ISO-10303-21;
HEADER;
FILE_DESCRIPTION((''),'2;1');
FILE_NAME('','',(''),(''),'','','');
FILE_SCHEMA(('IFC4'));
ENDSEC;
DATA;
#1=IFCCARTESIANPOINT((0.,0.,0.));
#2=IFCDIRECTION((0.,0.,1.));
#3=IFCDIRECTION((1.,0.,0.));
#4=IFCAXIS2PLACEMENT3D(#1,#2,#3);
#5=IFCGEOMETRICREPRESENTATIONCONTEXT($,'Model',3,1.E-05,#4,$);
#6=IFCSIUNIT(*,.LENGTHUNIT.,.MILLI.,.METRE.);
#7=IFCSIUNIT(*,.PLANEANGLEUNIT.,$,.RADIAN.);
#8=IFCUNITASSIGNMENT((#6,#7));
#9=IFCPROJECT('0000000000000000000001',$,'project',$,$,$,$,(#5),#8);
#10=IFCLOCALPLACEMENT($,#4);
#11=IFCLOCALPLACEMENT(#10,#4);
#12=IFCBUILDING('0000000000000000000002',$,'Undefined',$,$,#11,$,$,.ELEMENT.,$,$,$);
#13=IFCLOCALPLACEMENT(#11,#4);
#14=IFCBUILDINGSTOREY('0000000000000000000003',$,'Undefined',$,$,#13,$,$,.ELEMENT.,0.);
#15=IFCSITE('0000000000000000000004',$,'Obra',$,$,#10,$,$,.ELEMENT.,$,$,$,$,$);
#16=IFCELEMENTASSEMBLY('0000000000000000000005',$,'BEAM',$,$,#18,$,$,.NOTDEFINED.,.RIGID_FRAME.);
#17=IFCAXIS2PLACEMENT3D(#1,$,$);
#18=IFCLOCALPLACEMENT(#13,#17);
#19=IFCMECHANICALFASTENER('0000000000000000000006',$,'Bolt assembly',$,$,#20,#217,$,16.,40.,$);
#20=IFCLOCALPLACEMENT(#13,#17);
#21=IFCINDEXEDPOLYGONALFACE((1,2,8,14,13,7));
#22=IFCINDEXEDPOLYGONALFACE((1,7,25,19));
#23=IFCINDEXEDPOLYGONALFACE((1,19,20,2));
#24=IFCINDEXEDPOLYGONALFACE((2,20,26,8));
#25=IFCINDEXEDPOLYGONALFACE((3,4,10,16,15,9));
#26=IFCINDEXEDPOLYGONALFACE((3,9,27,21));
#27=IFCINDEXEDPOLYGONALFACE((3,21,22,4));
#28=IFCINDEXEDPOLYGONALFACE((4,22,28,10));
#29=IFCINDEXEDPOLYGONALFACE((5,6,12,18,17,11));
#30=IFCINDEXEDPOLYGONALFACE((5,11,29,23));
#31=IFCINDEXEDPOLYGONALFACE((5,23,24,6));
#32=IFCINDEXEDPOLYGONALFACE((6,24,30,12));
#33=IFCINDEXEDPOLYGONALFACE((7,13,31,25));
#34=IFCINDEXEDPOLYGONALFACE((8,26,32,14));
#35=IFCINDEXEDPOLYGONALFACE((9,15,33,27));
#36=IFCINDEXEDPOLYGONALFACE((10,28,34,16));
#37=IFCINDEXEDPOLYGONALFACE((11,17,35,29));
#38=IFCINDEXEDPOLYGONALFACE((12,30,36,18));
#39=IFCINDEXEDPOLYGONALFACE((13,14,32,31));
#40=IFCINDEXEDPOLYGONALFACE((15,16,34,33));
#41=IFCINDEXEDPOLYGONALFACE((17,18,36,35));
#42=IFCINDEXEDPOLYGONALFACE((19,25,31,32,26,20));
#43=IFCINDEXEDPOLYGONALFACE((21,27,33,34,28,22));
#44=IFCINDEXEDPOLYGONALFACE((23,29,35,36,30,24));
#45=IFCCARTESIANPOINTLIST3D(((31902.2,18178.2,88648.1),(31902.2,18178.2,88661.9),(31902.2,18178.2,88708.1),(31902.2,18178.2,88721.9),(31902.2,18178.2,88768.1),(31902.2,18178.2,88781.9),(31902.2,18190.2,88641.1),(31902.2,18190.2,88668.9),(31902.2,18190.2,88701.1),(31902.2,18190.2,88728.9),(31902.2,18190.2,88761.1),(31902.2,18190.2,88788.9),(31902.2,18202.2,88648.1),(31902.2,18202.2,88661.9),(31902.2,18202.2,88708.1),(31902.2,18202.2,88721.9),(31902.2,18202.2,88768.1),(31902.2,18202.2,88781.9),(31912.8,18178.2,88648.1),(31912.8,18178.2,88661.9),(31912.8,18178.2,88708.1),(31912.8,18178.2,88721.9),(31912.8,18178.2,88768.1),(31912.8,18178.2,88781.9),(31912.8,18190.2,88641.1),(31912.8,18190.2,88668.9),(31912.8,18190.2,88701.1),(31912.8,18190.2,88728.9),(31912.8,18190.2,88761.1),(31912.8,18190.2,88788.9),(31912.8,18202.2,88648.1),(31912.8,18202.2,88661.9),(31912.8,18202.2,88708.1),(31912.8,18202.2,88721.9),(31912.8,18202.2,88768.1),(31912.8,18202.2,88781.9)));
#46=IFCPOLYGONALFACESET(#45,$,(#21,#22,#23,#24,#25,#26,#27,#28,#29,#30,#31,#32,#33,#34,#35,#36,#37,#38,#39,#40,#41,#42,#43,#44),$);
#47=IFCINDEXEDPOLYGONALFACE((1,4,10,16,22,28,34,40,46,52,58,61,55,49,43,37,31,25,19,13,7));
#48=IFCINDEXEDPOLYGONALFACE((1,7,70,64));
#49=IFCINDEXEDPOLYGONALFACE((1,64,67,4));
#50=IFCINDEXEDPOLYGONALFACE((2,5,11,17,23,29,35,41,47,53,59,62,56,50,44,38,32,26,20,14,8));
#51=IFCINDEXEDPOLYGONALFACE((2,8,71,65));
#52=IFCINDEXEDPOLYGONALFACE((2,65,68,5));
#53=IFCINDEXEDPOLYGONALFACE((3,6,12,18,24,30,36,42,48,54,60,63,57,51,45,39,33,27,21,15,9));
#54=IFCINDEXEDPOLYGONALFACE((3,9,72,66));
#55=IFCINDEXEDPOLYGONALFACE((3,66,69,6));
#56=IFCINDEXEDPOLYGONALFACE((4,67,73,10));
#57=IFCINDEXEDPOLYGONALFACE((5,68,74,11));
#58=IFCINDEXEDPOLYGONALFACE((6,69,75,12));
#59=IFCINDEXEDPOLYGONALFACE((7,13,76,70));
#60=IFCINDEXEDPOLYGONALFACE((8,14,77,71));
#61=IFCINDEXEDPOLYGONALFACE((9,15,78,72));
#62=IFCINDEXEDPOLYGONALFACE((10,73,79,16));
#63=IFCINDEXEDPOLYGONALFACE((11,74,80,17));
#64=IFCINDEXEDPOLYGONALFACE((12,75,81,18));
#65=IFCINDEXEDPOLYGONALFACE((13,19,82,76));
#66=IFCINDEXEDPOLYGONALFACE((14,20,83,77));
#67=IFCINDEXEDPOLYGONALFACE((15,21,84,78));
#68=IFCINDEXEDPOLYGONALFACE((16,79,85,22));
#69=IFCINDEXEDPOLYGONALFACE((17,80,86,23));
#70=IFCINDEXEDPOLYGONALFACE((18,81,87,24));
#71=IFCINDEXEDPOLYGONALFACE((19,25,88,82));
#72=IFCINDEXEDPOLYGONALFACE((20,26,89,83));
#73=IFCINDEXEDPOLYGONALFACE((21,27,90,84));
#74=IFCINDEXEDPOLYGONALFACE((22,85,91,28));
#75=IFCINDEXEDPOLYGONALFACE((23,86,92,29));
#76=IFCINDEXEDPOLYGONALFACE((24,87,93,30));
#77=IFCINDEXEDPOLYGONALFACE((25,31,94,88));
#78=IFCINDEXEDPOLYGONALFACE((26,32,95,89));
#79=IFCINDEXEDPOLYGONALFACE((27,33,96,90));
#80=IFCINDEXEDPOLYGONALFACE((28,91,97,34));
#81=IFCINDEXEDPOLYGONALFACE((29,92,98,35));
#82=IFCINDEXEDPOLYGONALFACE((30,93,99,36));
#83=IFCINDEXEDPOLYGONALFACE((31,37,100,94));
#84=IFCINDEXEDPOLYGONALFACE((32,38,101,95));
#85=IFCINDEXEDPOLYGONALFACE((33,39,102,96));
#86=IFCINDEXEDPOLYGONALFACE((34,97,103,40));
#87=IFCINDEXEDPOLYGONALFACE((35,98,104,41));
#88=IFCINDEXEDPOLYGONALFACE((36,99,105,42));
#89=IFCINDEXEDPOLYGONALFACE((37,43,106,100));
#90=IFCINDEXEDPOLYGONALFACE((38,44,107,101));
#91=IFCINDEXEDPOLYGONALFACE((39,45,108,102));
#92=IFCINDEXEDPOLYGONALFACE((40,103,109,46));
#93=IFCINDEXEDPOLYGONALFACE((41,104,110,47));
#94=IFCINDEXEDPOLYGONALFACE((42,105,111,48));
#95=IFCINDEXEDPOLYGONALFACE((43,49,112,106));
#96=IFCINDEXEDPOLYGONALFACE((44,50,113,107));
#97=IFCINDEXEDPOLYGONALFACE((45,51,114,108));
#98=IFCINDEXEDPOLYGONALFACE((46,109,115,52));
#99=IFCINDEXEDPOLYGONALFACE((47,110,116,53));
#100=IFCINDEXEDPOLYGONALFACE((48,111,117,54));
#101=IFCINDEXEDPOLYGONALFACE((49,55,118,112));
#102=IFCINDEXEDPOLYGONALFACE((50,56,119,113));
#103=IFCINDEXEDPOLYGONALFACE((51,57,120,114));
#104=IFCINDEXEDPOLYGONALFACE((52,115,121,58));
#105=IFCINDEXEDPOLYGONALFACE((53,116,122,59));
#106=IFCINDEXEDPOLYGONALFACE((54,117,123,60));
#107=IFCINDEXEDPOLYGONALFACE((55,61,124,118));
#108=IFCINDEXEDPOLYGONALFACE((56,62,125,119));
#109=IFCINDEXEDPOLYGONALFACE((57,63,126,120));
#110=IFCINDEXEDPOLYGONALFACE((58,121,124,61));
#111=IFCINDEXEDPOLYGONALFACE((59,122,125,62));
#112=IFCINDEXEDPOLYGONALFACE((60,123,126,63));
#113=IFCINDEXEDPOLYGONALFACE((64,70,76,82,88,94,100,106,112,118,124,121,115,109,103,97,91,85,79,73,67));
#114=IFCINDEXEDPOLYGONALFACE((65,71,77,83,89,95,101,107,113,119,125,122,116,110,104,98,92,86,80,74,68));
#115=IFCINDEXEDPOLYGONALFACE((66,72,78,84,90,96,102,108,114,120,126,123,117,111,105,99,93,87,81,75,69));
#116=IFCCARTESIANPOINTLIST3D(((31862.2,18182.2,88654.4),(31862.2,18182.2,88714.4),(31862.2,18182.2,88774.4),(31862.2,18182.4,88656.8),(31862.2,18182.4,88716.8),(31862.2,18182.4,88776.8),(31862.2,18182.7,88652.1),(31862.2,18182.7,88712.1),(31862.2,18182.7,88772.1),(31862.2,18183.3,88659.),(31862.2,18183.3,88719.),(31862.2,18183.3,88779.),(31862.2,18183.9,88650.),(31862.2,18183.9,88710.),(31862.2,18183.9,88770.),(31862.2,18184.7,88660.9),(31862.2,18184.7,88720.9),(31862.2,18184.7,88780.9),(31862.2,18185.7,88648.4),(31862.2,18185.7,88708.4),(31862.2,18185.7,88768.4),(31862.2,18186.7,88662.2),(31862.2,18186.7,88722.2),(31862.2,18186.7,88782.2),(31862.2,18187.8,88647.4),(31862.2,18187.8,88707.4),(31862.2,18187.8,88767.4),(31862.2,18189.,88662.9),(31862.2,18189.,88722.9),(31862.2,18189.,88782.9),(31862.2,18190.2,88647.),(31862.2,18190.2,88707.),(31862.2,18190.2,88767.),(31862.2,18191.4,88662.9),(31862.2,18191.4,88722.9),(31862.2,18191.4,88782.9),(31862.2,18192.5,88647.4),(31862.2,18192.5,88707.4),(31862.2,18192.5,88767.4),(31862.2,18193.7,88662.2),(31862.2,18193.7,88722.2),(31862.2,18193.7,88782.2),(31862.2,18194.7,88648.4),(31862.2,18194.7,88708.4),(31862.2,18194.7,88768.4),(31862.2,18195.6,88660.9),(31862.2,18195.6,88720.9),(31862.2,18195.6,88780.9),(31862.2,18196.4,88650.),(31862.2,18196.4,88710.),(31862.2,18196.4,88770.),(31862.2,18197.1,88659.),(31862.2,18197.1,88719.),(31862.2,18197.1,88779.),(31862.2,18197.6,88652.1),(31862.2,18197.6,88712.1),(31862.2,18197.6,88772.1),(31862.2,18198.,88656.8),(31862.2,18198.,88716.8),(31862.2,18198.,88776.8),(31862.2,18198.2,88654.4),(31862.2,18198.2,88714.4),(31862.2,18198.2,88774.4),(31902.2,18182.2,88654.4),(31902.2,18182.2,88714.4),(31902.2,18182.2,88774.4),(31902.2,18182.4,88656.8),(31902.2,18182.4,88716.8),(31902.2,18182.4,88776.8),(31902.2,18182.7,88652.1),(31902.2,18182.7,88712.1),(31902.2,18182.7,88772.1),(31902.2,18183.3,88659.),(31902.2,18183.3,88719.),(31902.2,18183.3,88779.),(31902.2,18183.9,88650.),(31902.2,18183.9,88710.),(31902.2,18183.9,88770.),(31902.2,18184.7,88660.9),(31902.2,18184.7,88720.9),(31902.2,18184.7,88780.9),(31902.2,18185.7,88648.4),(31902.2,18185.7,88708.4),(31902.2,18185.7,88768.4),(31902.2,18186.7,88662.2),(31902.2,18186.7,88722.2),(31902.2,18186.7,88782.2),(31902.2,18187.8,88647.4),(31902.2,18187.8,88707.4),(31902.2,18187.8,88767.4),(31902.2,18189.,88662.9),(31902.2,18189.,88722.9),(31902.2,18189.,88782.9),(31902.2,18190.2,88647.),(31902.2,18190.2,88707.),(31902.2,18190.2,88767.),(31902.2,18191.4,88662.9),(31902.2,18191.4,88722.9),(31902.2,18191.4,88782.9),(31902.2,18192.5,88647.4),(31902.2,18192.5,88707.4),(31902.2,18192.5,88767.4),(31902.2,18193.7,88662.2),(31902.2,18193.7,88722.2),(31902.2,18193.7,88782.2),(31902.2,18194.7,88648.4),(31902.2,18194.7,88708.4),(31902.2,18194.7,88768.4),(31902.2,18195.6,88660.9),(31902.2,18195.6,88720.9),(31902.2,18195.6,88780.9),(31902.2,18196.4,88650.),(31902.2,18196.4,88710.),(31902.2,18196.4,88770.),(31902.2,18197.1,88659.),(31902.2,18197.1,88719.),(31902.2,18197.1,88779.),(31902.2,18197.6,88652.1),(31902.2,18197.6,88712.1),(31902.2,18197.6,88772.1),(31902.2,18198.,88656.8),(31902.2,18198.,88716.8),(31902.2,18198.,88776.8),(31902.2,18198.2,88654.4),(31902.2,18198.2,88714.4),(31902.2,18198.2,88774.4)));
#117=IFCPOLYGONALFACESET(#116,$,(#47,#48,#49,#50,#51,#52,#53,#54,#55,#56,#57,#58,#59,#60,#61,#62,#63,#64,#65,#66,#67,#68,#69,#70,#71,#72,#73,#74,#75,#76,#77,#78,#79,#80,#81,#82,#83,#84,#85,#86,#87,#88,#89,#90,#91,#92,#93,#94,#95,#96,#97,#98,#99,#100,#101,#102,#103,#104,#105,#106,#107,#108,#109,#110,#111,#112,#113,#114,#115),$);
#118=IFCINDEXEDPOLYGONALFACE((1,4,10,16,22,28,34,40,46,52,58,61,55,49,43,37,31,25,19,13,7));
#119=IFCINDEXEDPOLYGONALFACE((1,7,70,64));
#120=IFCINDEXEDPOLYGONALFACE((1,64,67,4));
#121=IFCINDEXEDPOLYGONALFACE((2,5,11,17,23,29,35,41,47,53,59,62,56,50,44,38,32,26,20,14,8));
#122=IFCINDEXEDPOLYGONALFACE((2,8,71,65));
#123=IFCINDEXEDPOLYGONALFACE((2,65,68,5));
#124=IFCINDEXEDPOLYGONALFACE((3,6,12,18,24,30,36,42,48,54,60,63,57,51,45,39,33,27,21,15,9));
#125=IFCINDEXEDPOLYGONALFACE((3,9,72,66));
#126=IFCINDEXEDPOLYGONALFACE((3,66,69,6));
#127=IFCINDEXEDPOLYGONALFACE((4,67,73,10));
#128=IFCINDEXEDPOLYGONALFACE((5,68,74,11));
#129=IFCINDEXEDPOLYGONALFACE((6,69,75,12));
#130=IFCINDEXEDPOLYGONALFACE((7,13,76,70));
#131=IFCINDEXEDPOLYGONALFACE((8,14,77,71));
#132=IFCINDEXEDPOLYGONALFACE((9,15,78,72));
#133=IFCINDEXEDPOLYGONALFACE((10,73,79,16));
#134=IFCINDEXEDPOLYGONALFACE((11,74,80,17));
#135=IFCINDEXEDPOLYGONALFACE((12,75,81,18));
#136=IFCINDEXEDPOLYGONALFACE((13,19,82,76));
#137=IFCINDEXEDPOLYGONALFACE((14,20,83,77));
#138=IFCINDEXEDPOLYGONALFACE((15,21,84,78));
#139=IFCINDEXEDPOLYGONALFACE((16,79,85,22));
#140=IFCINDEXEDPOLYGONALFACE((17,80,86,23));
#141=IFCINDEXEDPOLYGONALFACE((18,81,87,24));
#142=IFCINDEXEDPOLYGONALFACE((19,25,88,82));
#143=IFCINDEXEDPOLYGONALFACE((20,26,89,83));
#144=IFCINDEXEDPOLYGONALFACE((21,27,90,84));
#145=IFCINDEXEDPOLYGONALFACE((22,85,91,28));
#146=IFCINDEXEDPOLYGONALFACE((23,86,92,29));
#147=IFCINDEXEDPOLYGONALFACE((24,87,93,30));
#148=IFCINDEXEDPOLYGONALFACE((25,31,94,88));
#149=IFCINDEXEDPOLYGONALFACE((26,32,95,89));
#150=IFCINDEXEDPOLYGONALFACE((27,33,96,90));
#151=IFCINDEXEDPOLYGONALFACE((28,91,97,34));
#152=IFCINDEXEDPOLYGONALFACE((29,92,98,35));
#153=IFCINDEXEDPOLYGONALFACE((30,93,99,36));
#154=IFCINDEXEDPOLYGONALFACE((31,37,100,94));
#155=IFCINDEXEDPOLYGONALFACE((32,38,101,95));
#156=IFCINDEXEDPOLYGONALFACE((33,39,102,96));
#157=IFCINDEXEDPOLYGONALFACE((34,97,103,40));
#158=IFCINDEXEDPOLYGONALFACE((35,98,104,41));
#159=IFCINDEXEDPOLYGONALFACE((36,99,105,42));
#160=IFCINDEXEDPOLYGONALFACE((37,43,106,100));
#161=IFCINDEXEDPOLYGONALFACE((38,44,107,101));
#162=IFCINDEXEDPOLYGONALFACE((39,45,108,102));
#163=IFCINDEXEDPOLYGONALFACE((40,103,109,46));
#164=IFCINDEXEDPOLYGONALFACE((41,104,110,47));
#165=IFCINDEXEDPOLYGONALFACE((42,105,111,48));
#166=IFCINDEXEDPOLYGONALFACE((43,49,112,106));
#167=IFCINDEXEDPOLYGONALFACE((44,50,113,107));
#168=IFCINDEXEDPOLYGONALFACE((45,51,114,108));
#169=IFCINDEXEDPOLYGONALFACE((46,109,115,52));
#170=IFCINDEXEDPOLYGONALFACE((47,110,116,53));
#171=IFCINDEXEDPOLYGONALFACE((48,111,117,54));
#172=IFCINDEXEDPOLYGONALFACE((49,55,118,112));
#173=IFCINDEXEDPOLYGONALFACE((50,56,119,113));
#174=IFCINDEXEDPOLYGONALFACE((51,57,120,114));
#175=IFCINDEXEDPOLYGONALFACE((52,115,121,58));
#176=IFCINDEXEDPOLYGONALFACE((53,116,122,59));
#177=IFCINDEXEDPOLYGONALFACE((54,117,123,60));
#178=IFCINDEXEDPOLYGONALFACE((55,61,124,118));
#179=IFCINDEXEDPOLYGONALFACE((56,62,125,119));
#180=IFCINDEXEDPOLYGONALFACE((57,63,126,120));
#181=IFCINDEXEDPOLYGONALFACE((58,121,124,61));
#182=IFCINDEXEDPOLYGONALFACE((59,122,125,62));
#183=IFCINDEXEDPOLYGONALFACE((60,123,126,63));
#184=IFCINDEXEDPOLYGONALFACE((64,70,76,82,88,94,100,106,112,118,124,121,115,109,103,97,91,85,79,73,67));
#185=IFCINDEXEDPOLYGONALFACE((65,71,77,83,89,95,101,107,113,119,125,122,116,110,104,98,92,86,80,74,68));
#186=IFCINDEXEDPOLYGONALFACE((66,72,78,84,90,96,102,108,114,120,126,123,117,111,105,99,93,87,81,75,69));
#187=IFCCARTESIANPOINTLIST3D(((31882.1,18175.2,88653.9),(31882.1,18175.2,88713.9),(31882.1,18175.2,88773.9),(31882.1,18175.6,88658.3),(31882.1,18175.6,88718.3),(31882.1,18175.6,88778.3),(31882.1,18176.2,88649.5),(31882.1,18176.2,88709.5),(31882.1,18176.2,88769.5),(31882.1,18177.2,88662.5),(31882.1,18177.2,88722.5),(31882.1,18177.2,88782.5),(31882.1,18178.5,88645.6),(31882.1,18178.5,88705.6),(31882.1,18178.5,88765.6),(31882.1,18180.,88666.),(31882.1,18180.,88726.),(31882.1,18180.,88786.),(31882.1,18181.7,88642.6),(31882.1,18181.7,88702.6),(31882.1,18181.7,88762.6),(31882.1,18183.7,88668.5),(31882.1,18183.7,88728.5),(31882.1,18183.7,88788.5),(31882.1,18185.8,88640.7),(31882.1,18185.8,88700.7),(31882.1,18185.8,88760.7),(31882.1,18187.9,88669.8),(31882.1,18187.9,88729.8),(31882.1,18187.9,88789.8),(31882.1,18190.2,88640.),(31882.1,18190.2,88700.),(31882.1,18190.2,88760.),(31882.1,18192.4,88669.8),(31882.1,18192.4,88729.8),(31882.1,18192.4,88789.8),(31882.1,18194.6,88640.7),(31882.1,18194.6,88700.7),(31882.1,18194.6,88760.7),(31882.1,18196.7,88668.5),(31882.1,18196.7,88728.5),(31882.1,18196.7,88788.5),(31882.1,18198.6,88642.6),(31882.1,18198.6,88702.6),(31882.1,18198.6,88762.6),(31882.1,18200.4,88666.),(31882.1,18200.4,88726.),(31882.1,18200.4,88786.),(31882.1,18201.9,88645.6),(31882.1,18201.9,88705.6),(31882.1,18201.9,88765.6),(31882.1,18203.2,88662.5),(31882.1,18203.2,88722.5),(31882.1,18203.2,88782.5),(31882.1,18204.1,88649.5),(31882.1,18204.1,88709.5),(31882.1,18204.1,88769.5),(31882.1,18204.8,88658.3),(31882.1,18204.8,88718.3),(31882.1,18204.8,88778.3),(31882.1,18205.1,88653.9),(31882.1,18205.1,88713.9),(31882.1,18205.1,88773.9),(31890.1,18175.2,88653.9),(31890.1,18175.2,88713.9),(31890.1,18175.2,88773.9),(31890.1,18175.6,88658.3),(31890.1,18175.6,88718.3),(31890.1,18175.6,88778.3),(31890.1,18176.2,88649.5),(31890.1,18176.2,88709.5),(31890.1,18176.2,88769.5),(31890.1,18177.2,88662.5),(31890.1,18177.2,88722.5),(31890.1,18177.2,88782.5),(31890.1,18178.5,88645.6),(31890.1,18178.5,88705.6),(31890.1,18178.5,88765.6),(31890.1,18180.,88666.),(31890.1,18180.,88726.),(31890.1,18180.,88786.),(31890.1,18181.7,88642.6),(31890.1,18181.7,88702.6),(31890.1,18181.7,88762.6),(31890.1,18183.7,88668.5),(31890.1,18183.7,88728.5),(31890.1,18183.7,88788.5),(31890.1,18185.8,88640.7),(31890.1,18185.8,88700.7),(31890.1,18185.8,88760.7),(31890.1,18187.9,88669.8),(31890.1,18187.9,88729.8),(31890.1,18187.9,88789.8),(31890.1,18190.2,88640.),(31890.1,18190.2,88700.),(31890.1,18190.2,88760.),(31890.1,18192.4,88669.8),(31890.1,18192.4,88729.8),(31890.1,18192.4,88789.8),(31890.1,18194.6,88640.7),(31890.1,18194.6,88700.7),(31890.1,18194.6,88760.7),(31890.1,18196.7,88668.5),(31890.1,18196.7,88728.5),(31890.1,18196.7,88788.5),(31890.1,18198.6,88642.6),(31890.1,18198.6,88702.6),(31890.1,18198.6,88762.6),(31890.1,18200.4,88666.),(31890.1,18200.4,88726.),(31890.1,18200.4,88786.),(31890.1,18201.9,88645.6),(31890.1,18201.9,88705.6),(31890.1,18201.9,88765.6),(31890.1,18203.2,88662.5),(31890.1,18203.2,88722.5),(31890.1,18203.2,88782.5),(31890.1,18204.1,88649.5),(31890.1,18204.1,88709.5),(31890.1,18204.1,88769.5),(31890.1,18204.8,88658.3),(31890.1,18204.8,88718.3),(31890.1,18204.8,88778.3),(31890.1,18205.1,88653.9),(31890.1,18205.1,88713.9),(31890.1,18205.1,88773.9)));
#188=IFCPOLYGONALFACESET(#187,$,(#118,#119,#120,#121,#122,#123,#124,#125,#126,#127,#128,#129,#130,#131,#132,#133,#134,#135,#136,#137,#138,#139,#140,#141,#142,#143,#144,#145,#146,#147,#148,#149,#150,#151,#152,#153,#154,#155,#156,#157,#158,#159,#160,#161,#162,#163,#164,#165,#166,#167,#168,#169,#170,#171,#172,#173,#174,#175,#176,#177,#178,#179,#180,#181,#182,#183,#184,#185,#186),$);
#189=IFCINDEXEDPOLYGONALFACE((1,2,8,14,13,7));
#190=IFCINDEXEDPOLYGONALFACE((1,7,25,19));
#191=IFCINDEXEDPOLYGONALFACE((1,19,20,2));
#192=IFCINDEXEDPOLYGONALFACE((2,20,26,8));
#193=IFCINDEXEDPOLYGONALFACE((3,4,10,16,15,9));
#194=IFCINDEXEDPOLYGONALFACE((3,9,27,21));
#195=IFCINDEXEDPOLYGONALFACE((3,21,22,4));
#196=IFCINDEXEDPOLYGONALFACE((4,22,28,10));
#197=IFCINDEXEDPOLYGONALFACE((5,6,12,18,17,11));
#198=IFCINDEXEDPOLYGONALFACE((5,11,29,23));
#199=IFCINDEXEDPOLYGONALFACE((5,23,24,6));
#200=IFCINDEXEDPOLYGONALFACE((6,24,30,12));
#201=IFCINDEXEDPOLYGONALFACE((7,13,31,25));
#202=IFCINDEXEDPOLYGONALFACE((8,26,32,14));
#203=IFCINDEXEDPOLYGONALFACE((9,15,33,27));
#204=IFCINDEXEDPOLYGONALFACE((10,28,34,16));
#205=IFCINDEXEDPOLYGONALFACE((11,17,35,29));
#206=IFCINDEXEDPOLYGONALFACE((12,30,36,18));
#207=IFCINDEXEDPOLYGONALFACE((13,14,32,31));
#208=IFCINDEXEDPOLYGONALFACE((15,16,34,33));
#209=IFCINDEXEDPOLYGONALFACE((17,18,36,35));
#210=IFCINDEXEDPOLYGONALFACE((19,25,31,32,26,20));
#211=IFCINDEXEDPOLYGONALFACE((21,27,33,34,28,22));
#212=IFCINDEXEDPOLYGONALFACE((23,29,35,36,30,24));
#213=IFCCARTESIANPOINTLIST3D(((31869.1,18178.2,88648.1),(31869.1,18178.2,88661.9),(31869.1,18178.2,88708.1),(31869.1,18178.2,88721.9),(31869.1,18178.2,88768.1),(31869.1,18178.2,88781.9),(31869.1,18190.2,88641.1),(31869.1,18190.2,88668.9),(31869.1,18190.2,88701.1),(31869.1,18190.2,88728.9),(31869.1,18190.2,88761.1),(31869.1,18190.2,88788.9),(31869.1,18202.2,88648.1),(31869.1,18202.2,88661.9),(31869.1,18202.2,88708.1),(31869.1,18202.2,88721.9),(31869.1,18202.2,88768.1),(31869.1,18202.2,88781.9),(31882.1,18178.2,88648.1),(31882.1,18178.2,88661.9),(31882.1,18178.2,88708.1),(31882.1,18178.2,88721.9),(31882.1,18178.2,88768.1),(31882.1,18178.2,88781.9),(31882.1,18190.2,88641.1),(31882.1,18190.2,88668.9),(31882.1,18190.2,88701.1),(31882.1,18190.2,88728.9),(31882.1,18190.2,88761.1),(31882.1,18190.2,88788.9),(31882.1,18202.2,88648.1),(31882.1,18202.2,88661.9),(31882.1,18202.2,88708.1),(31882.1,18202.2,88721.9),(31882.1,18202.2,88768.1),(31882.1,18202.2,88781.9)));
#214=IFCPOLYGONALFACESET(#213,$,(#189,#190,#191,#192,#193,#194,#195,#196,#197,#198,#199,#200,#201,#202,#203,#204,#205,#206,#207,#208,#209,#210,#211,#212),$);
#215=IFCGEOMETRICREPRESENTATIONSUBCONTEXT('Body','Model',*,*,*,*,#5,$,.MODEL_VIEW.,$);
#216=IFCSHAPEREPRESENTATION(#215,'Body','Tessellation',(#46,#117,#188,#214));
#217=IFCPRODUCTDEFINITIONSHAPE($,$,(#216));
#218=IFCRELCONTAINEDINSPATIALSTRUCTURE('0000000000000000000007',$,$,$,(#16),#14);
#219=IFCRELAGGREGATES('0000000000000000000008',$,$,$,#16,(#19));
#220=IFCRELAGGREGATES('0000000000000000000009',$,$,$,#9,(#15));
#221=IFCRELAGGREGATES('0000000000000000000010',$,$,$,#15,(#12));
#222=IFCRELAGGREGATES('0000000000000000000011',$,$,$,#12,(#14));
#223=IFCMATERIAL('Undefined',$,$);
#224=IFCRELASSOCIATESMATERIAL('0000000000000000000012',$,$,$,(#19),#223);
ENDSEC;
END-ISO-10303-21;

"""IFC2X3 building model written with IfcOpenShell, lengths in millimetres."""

from ifc_helpers import new_model, si_unit, frame, origin_with_axes, origin_2d_with_axis, place, context, subcontext, project, spatial, polyline, circle, outline, extrude, source, transform, mapped, material, element, aggregate, save


model = new_model("IFC2X3")

# Units and contexts
model_context = context("Model", 3, precision=1e-05, world=origin_with_axes())
body_context = subcontext(model_context, "Body", "Model", "MODEL_VIEW")
ifc_project = project(units=[si_unit("LENGTHUNIT", "METRE", prefix="MILLI"), si_unit("PLANEANGLEUNIT", "RADIAN")], contexts=[model_context])

# Site, building, storey
site_placement = place(None, origin_with_axes())
site = spatial("IfcSite", under=ifc_project, at=site_placement, Name="Obra", CompositionType="ELEMENT")
building_placement = place(site_placement, origin_with_axes())
building = spatial("IfcBuilding", under=site, at=building_placement, Name="Undefined", CompositionType="ELEMENT")
storey_placement = place(building_placement, origin_with_axes())
storey = spatial("IfcBuildingStorey", under=building, at=storey_placement, Name="Undefined", CompositionType="ELEMENT", Elevation=0.0)

# Shared definitions
ifc_material_1 = material(Name="Undefined")

# Element assembly, mechanical fastener
assembly_1_placement = place(storey_placement, origin_with_axes())
assembly_1 = element("IfcElementAssembly", 1, at=assembly_1_placement, inside=storey, Name="BEAM", AssemblyPlace="NOTDEFINED", PredefinedType="RIGID_FRAME")
shared_shape_1 = source(origin_with_axes(), body_context, "Body", "SweptSolid", [
    extrude(outline(polyline([(13.9, 0.0), (6.9, 12.0), (-6.9, 12.0), (-13.9, 0.0), (-6.9, -12.0), (6.9, -12.0), (13.9, 0.0)])), frame((0.0, -19.7, 0.0), z_axis=(0.0, 1.0, 0.0), x_axis=(1.0, 0.0, 0.0)), (0.0, 0.0, 1.0), 10.6),
    extrude(circle(Radius=8.0, at=origin_2d_with_axis()), frame((0.0, -9.1, 0.0), z_axis=(0.0, 1.0, 0.0), x_axis=(1.0, 0.0, 0.0)), (0.0, 0.0, 1.0), 40.0),
    extrude(circle(Radius=15.0, at=origin_2d_with_axis()), frame((0.0, 3.0, 0.0), z_axis=(0.0, 1.0, 0.0), x_axis=(1.0, 0.0, 0.0)), (0.0, 0.0, 1.0), 8.0),
    extrude(outline(polyline([(13.9, 0.0), (6.9, 12.0), (-6.9, 12.0), (-13.9, 0.0), (-6.9, -12.0), (6.9, -12.0), (13.9, 0.0)])), frame((0.0, 11.0, 0.0), z_axis=(0.0, 1.0, 0.0), x_axis=(1.0, 0.0, 0.0)), (0.0, 0.0, 1.0), 13.0),
])
mechanical_fastener_1_placement = place(assembly_1_placement, frame((31893.1, 18140.2, 88835.0), z_axis=(-0.000002, 1.0, 0.0), x_axis=(0.0, 0.0, -1.0)))
mechanical_fastener_1 = element("IfcMechanicalFastener", 2, at=mechanical_fastener_1_placement, material=ifc_material_1, Name="Bolt assembly", NominalDiameter=16.0, NominalLength=40.0, context=body_context, shape_type="MappedRepresentation", body=[
    mapped(shared_shape_1, transform((60.0, 0.0, 50.0))),
    mapped(shared_shape_1, transform((120.0, 0.0, 50.0))),
    mapped(shared_shape_1, transform((180.0, 0.0, 50.0))),
])

aggregate(assembly_1, [mechanical_fastener_1])

save(model, "model.ifc")
